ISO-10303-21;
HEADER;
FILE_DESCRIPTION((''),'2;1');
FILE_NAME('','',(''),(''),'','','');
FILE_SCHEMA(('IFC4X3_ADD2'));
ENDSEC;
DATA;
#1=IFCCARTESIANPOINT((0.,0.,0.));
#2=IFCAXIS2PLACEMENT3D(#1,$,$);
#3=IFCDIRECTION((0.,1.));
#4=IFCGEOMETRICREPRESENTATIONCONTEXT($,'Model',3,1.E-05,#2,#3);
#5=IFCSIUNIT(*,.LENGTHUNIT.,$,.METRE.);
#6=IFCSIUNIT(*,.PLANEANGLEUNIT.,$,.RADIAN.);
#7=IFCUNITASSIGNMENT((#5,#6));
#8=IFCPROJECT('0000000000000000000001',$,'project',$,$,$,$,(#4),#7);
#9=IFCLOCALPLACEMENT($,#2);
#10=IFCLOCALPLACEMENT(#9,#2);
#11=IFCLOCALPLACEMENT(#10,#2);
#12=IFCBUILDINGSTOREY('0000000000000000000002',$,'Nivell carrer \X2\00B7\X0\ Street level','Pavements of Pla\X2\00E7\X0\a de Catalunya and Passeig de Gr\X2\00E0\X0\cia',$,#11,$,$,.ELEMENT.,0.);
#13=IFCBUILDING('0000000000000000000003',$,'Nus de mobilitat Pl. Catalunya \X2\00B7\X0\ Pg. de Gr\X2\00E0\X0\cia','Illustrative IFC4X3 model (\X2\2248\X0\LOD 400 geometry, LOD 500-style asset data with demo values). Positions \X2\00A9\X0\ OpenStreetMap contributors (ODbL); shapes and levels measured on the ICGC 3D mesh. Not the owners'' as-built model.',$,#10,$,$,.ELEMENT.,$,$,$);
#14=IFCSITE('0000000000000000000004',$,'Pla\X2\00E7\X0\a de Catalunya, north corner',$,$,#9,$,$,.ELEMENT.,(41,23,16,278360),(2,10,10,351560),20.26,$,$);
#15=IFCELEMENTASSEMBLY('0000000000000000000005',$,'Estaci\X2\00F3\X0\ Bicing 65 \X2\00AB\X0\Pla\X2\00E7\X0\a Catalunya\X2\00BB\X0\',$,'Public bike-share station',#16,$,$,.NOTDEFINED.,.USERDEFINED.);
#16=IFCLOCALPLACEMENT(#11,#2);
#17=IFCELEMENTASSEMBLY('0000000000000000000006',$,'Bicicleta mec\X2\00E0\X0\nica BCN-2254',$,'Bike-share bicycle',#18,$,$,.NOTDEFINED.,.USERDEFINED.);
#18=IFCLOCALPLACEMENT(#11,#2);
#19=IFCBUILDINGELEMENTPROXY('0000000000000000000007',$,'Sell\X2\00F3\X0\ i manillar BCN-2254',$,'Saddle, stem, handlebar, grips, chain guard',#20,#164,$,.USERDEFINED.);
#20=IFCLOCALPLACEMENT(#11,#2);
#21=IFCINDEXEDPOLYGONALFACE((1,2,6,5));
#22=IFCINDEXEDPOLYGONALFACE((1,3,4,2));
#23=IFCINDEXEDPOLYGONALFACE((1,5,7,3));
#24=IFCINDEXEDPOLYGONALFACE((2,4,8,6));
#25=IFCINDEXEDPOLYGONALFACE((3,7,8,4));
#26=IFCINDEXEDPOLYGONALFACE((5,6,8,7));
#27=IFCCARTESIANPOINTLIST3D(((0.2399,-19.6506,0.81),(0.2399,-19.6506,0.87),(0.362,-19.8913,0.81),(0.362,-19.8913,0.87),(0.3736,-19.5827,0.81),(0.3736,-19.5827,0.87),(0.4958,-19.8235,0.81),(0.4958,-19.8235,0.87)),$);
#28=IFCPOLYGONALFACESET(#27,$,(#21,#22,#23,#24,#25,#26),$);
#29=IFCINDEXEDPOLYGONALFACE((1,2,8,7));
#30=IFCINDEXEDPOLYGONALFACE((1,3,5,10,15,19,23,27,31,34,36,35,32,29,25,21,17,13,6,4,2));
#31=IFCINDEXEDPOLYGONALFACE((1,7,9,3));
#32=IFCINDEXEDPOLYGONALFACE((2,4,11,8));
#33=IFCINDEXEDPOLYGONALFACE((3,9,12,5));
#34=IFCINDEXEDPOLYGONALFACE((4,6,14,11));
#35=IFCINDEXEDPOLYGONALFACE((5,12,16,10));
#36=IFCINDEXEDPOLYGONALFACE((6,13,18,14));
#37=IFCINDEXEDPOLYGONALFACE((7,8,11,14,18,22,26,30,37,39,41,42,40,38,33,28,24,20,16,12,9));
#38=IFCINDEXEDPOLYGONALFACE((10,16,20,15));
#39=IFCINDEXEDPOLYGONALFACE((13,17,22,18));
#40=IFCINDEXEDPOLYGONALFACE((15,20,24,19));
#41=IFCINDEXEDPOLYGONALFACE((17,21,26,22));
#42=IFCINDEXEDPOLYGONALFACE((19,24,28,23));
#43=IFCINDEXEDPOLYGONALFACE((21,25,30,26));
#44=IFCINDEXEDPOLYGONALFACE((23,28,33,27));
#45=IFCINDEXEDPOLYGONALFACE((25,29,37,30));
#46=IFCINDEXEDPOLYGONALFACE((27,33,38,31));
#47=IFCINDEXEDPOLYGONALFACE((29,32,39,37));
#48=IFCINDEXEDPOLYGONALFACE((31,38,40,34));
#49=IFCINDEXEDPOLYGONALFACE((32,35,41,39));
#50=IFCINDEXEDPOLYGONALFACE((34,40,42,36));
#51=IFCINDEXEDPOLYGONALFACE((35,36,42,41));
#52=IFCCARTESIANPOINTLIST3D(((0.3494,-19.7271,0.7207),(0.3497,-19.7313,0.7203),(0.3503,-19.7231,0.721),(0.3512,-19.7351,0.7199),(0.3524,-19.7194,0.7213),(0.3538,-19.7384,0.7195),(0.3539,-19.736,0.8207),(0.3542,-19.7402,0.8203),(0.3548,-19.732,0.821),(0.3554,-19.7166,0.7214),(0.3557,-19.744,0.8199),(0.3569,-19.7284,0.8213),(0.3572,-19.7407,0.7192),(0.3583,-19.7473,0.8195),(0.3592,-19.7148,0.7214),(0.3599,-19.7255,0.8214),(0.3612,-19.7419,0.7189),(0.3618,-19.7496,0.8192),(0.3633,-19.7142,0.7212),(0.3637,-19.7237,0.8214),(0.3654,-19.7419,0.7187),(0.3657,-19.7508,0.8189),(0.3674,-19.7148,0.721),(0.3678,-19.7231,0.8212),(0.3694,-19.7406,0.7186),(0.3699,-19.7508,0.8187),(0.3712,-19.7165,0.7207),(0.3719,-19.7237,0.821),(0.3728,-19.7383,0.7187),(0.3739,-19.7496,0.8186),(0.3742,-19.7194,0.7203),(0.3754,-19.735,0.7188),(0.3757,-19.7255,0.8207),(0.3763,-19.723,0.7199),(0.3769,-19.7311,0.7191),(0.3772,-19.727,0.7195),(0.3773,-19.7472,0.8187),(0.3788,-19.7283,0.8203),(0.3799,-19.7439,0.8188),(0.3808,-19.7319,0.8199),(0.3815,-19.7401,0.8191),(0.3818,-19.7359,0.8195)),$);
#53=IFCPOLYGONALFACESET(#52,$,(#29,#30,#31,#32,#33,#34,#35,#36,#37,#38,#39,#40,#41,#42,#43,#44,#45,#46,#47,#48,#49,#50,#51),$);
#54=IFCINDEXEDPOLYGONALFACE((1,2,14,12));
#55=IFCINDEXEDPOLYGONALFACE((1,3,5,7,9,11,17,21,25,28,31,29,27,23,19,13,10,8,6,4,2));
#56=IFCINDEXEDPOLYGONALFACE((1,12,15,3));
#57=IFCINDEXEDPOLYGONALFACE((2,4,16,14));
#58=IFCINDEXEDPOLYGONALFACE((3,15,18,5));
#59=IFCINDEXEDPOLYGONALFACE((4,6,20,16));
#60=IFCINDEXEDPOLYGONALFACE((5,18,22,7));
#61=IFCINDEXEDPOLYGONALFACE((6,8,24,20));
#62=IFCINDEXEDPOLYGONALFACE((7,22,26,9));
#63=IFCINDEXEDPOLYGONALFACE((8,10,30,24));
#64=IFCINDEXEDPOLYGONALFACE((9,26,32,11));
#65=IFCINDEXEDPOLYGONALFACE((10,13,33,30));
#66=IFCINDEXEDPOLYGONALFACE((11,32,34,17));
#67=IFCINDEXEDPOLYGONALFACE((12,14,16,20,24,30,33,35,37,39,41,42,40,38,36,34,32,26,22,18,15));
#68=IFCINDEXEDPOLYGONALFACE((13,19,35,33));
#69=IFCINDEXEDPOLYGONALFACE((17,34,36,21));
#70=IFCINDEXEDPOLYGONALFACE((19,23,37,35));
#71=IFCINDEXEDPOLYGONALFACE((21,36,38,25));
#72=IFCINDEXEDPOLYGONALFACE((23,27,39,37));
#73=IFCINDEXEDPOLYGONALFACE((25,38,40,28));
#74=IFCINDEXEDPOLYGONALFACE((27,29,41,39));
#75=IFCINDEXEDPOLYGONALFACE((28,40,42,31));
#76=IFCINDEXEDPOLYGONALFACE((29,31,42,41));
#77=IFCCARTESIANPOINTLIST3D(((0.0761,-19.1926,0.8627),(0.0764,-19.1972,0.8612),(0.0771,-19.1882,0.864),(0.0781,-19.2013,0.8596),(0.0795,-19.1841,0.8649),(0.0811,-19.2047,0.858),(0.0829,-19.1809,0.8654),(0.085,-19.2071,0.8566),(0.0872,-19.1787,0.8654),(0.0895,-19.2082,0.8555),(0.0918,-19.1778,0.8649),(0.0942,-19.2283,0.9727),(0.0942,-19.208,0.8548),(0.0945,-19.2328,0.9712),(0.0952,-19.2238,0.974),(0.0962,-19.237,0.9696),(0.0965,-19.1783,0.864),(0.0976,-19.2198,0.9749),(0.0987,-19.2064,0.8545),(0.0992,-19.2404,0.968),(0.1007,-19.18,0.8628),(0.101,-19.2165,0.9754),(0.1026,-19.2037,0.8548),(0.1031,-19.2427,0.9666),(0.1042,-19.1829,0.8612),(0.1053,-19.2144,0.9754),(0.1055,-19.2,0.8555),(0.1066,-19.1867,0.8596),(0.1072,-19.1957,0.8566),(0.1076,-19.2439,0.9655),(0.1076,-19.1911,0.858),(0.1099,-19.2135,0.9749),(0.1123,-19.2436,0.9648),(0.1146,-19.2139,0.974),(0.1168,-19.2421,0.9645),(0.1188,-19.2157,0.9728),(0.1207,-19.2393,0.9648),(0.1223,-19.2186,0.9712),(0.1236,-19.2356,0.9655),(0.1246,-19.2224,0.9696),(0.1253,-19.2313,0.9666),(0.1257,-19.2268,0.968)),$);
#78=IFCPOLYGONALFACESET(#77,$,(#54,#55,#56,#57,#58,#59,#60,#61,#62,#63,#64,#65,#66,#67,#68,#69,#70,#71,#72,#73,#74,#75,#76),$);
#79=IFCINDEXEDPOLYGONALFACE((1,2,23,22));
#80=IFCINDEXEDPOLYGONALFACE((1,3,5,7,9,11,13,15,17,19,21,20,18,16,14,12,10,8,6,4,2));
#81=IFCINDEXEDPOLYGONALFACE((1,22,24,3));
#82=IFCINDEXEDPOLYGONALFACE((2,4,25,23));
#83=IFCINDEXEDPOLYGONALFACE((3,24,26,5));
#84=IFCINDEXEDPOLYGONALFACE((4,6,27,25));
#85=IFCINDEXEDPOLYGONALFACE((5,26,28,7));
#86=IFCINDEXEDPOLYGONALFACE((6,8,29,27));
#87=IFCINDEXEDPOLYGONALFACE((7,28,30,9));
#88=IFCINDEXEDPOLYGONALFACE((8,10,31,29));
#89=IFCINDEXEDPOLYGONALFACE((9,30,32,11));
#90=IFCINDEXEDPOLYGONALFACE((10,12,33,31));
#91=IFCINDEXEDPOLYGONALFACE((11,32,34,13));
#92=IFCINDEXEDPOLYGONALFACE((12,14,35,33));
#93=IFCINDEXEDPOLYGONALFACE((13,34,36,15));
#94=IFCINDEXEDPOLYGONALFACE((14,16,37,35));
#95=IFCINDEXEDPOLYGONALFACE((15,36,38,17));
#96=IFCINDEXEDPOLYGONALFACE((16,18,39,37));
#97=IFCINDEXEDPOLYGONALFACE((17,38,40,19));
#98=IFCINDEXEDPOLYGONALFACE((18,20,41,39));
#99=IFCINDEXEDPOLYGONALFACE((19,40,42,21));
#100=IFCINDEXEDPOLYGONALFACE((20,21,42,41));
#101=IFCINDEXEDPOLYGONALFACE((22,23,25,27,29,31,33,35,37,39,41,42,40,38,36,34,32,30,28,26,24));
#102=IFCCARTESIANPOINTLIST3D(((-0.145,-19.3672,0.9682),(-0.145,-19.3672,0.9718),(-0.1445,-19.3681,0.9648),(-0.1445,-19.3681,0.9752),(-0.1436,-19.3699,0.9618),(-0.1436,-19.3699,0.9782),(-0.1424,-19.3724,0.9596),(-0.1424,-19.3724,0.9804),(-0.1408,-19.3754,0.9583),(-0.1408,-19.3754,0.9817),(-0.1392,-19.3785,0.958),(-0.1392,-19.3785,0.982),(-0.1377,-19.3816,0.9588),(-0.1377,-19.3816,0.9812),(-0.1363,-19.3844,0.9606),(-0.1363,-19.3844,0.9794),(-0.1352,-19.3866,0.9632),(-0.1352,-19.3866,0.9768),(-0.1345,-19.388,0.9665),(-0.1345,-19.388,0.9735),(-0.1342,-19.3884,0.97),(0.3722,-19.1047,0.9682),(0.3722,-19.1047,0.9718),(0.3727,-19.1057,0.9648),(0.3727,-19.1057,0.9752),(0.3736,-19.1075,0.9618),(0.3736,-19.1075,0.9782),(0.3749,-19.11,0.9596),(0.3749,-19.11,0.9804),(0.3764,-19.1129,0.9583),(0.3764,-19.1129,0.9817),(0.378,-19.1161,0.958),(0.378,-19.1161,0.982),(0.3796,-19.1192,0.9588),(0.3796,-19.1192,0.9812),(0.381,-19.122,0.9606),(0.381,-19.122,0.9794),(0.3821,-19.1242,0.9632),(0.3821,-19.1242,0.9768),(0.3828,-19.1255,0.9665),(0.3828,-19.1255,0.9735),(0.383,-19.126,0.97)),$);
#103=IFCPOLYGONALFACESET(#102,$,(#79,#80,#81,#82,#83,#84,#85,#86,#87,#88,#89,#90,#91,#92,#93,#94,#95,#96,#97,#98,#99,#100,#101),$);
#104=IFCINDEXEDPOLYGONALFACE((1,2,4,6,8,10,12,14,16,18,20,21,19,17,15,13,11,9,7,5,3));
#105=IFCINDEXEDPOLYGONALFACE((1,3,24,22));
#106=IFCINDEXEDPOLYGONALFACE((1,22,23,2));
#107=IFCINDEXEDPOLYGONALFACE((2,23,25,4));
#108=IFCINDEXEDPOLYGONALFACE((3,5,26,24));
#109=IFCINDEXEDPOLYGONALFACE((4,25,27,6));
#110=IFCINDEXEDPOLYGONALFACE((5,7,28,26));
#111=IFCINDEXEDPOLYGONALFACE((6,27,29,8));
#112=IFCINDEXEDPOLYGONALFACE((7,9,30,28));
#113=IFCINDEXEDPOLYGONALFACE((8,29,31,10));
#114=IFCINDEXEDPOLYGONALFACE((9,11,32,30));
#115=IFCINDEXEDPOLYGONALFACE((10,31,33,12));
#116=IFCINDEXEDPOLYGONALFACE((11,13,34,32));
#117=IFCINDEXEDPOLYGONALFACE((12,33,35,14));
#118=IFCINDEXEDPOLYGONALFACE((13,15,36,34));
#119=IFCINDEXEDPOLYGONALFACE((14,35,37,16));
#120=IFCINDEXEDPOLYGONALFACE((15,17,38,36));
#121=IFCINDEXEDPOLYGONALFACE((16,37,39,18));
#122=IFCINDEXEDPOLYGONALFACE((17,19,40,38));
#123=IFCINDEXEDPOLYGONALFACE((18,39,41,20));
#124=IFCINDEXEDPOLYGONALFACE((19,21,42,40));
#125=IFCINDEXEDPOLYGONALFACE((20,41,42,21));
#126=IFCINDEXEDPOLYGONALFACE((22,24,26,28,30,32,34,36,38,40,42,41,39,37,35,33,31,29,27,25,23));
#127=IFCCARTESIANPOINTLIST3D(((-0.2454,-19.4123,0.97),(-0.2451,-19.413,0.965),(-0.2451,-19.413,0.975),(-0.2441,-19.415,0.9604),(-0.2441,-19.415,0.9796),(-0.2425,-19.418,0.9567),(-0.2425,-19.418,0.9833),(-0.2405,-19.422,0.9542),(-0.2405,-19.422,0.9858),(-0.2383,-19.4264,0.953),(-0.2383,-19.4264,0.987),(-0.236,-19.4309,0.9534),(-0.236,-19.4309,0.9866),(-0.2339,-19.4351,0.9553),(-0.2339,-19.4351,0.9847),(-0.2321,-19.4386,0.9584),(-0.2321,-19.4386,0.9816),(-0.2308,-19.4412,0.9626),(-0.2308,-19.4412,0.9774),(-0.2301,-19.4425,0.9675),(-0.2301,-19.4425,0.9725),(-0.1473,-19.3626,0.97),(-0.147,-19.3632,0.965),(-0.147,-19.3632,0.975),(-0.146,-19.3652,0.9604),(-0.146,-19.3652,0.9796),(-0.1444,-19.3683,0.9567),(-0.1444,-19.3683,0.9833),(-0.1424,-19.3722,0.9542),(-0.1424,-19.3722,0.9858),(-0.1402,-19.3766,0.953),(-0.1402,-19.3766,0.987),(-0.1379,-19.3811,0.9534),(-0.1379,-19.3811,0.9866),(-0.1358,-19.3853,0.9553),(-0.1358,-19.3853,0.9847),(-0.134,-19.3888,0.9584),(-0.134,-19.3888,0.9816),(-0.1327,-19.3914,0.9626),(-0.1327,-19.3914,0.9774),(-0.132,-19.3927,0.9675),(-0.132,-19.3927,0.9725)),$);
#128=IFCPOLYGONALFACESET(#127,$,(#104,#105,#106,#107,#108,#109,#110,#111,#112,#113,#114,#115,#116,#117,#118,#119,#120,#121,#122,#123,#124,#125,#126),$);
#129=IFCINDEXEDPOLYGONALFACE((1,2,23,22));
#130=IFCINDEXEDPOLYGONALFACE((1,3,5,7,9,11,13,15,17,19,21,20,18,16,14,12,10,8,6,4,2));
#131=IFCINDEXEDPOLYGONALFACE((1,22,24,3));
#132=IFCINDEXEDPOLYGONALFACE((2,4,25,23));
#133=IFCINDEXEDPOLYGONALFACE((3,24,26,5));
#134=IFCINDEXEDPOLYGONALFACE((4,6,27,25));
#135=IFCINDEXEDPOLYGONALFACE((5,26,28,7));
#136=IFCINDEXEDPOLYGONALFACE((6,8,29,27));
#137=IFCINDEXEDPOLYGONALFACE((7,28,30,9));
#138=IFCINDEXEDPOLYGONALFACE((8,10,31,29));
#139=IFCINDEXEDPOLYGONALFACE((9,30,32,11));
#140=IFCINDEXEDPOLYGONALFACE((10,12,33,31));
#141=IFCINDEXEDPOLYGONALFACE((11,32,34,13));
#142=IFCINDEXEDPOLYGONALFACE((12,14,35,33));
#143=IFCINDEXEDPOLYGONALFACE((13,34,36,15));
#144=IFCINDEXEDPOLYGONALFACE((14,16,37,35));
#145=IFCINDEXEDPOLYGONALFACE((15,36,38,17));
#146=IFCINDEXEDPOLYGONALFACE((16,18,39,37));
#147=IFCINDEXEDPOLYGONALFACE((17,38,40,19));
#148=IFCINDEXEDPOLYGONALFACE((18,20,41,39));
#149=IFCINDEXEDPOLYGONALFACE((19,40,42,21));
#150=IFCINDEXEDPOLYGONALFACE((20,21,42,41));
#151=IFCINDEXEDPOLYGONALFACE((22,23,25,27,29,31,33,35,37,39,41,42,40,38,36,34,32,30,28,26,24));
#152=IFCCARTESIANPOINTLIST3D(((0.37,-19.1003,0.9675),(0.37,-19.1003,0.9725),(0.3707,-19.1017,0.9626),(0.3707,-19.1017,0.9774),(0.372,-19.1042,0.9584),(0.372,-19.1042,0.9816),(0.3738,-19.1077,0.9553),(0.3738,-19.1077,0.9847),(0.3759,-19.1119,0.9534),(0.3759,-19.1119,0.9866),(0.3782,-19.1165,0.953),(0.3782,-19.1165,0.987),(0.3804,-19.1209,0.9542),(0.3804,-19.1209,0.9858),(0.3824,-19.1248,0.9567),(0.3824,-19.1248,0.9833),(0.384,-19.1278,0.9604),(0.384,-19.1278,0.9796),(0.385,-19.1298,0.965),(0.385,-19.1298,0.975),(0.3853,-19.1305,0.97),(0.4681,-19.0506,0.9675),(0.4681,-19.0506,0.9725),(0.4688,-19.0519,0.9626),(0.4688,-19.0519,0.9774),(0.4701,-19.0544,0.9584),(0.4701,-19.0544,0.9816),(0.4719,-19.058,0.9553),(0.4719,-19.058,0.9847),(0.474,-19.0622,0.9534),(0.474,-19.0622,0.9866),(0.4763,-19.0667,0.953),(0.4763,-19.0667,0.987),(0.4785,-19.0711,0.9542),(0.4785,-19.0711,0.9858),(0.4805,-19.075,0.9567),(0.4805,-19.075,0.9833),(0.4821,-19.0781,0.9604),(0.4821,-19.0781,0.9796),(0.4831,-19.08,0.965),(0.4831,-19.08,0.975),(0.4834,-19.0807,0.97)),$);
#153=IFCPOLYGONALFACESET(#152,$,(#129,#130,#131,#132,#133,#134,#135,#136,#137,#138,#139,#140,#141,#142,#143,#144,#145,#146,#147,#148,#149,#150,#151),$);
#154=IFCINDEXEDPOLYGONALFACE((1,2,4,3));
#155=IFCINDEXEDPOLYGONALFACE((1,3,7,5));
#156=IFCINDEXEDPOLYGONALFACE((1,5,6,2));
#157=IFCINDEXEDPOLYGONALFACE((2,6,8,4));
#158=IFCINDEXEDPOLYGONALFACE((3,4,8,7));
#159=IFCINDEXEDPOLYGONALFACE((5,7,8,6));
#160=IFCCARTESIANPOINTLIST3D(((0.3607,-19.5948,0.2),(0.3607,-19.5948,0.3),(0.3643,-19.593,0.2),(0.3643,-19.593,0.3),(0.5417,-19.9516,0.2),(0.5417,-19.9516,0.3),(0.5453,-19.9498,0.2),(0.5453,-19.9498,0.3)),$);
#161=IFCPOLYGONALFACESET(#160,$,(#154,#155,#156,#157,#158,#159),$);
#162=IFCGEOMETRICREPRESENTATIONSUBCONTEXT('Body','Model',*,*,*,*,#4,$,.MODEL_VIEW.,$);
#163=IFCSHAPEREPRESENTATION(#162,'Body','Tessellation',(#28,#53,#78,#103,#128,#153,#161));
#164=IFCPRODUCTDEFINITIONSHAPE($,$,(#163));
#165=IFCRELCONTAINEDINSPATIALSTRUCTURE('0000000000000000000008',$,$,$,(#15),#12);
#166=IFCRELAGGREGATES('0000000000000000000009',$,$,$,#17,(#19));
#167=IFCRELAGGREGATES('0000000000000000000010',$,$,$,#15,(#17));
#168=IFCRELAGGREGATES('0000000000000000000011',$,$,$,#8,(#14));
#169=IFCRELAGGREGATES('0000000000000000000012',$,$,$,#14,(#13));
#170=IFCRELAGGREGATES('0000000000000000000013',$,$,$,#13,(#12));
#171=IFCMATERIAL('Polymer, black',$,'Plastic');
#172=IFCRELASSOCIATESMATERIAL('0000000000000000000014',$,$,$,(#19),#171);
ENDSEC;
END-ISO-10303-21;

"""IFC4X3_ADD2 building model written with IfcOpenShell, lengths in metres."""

from ifc_helpers import new_model, si_unit, direction, frame, origin, origin_2d_with_axis, place, context, subcontext, project, spatial, rectangle, circle, extrude, material, element, aggregate, save


model = new_model("IFC4X3_ADD2")

# Units and contexts
model_context = context("Model", 3, precision=1e-05, world=origin(), true_north=direction((0.0, 1.0)))
body_context = subcontext(model_context, "Body", "Model", "MODEL_VIEW")
ifc_project = project(units=[si_unit("LENGTHUNIT", "METRE"), si_unit("PLANEANGLEUNIT", "RADIAN")], contexts=[model_context])

# Site, building, storey
site_placement = place(None, origin())
site = spatial("IfcSite", under=ifc_project, at=site_placement, Name="Plaça de Catalunya, north corner", CompositionType="ELEMENT", RefLatitude=(41, 23, 16, 278360), RefLongitude=(2, 10, 10, 351560), RefElevation=20.26)
building_placement = place(site_placement, origin())
building = spatial("IfcBuilding", under=site, at=building_placement, Name="Nus de mobilitat Pl. Catalunya · Pg. de Gràcia", Description="Illustrative IFC4X3 model (≈LOD 400 geometry, LOD 500-style asset data with demo values). Positions © OpenStreetMap contributors (ODbL); shapes and levels measured on the ICGC 3D mesh. Not the owners' as-built model.", CompositionType="ELEMENT")
storey_placement = place(building_placement, origin())
storey = spatial("IfcBuildingStorey", under=building, at=storey_placement, Name="Nivell carrer · Street level", Description="Pavements of Plaça de Catalunya and Passeig de Gràcia", CompositionType="ELEMENT", Elevation=0.0)

# Element assemblies, building element proxy
assembly_1_placement = place(building_placement, origin())
assembly_1 = element("IfcElementAssembly", 1, at=assembly_1_placement, inside=storey, Name="Estació Bicing 65 «Plaça Catalunya»", ObjectType="Public bike-share station", AssemblyPlace="NOTDEFINED", PredefinedType="USERDEFINED")
assembly_2_placement = place(building_placement, origin())
assembly_2 = element("IfcElementAssembly", 2, at=assembly_2_placement, Name="Bicicleta mecànica BCN-2254", ObjectType="Bike-share bicycle", AssemblyPlace="NOTDEFINED", PredefinedType="USERDEFINED")
ifc_material_1 = material(Name="Polymer, black", Category="Plastic")
proxy_1_placement = place(building_placement, origin())
proxy_1 = element("IfcBuildingElementProxy", 3, at=proxy_1_placement, material=ifc_material_1, Name="Selló i manillar BCN-2254", ObjectType="Saddle, stem, handlebar, grips, chain guard", PredefinedType="USERDEFINED", context=body_context, shape_type="SweptSolid", body=[
    extrude(rectangle(XDim=0.27, YDim=0.15, at=origin_2d_with_axis()), frame((0.3678, -19.737, 0.87), z_axis=(0.0, 0.0, -1.0), x_axis=(-0.452435, 0.891798, 0.0)), (0.0, 0.0, 1.0), 0.06),
    extrude(circle(Radius=0.014, at=origin_2d_with_axis()), frame((0.3633, -19.7281, 0.72), z_axis=(0.045019, -0.088737, 0.995037), x_axis=(0.0, 0.996047, 0.088827)), (0.0, 0.0, 1.0), 0.1005),
    extrude(circle(Radius=0.016, at=origin_2d_with_axis()), frame((0.0918, -19.193, 0.86), z_axis=(0.154616, -0.304766, 0.939793), x_axis=(0.0, 0.951232, 0.308475)), (0.0, 0.0, 1.0), 0.117),
    extrude(circle(Radius=0.012, at=origin_2d_with_axis()), frame((-0.1396, -19.3777, 0.97), z_axis=(0.891798, 0.452435, 0.0), x_axis=(0.452435, -0.891798, 0.0)), (0.0, 0.0, 1.0), 0.58),
    extrude(circle(Radius=0.017, at=origin_2d_with_axis()), frame((-0.1396, -19.3777, 0.97), z_axis=(-0.891798, -0.452435, 0.0), x_axis=(-0.452435, 0.891798, 0.0)), (0.0, 0.0, 1.0), 0.11),
    extrude(circle(Radius=0.017, at=origin_2d_with_axis()), frame((0.3776, -19.1153, 0.97), z_axis=(0.891798, 0.452435, 0.0), x_axis=(0.452435, -0.891798, 0.0)), (0.0, 0.0, 1.0), 0.11),
    extrude(rectangle(XDim=0.4, YDim=0.1, at=origin_2d_with_axis()), frame((0.4512, -19.7732, 0.25), z_axis=(0.891798, 0.452435, 0.0), x_axis=(-0.452435, 0.891798, 0.0)), (0.0, 0.0, 1.0), 0.004),
])
aggregate(assembly_2, [proxy_1])
aggregate(assembly_1, [assembly_2])

save(model, "model.ifc")
